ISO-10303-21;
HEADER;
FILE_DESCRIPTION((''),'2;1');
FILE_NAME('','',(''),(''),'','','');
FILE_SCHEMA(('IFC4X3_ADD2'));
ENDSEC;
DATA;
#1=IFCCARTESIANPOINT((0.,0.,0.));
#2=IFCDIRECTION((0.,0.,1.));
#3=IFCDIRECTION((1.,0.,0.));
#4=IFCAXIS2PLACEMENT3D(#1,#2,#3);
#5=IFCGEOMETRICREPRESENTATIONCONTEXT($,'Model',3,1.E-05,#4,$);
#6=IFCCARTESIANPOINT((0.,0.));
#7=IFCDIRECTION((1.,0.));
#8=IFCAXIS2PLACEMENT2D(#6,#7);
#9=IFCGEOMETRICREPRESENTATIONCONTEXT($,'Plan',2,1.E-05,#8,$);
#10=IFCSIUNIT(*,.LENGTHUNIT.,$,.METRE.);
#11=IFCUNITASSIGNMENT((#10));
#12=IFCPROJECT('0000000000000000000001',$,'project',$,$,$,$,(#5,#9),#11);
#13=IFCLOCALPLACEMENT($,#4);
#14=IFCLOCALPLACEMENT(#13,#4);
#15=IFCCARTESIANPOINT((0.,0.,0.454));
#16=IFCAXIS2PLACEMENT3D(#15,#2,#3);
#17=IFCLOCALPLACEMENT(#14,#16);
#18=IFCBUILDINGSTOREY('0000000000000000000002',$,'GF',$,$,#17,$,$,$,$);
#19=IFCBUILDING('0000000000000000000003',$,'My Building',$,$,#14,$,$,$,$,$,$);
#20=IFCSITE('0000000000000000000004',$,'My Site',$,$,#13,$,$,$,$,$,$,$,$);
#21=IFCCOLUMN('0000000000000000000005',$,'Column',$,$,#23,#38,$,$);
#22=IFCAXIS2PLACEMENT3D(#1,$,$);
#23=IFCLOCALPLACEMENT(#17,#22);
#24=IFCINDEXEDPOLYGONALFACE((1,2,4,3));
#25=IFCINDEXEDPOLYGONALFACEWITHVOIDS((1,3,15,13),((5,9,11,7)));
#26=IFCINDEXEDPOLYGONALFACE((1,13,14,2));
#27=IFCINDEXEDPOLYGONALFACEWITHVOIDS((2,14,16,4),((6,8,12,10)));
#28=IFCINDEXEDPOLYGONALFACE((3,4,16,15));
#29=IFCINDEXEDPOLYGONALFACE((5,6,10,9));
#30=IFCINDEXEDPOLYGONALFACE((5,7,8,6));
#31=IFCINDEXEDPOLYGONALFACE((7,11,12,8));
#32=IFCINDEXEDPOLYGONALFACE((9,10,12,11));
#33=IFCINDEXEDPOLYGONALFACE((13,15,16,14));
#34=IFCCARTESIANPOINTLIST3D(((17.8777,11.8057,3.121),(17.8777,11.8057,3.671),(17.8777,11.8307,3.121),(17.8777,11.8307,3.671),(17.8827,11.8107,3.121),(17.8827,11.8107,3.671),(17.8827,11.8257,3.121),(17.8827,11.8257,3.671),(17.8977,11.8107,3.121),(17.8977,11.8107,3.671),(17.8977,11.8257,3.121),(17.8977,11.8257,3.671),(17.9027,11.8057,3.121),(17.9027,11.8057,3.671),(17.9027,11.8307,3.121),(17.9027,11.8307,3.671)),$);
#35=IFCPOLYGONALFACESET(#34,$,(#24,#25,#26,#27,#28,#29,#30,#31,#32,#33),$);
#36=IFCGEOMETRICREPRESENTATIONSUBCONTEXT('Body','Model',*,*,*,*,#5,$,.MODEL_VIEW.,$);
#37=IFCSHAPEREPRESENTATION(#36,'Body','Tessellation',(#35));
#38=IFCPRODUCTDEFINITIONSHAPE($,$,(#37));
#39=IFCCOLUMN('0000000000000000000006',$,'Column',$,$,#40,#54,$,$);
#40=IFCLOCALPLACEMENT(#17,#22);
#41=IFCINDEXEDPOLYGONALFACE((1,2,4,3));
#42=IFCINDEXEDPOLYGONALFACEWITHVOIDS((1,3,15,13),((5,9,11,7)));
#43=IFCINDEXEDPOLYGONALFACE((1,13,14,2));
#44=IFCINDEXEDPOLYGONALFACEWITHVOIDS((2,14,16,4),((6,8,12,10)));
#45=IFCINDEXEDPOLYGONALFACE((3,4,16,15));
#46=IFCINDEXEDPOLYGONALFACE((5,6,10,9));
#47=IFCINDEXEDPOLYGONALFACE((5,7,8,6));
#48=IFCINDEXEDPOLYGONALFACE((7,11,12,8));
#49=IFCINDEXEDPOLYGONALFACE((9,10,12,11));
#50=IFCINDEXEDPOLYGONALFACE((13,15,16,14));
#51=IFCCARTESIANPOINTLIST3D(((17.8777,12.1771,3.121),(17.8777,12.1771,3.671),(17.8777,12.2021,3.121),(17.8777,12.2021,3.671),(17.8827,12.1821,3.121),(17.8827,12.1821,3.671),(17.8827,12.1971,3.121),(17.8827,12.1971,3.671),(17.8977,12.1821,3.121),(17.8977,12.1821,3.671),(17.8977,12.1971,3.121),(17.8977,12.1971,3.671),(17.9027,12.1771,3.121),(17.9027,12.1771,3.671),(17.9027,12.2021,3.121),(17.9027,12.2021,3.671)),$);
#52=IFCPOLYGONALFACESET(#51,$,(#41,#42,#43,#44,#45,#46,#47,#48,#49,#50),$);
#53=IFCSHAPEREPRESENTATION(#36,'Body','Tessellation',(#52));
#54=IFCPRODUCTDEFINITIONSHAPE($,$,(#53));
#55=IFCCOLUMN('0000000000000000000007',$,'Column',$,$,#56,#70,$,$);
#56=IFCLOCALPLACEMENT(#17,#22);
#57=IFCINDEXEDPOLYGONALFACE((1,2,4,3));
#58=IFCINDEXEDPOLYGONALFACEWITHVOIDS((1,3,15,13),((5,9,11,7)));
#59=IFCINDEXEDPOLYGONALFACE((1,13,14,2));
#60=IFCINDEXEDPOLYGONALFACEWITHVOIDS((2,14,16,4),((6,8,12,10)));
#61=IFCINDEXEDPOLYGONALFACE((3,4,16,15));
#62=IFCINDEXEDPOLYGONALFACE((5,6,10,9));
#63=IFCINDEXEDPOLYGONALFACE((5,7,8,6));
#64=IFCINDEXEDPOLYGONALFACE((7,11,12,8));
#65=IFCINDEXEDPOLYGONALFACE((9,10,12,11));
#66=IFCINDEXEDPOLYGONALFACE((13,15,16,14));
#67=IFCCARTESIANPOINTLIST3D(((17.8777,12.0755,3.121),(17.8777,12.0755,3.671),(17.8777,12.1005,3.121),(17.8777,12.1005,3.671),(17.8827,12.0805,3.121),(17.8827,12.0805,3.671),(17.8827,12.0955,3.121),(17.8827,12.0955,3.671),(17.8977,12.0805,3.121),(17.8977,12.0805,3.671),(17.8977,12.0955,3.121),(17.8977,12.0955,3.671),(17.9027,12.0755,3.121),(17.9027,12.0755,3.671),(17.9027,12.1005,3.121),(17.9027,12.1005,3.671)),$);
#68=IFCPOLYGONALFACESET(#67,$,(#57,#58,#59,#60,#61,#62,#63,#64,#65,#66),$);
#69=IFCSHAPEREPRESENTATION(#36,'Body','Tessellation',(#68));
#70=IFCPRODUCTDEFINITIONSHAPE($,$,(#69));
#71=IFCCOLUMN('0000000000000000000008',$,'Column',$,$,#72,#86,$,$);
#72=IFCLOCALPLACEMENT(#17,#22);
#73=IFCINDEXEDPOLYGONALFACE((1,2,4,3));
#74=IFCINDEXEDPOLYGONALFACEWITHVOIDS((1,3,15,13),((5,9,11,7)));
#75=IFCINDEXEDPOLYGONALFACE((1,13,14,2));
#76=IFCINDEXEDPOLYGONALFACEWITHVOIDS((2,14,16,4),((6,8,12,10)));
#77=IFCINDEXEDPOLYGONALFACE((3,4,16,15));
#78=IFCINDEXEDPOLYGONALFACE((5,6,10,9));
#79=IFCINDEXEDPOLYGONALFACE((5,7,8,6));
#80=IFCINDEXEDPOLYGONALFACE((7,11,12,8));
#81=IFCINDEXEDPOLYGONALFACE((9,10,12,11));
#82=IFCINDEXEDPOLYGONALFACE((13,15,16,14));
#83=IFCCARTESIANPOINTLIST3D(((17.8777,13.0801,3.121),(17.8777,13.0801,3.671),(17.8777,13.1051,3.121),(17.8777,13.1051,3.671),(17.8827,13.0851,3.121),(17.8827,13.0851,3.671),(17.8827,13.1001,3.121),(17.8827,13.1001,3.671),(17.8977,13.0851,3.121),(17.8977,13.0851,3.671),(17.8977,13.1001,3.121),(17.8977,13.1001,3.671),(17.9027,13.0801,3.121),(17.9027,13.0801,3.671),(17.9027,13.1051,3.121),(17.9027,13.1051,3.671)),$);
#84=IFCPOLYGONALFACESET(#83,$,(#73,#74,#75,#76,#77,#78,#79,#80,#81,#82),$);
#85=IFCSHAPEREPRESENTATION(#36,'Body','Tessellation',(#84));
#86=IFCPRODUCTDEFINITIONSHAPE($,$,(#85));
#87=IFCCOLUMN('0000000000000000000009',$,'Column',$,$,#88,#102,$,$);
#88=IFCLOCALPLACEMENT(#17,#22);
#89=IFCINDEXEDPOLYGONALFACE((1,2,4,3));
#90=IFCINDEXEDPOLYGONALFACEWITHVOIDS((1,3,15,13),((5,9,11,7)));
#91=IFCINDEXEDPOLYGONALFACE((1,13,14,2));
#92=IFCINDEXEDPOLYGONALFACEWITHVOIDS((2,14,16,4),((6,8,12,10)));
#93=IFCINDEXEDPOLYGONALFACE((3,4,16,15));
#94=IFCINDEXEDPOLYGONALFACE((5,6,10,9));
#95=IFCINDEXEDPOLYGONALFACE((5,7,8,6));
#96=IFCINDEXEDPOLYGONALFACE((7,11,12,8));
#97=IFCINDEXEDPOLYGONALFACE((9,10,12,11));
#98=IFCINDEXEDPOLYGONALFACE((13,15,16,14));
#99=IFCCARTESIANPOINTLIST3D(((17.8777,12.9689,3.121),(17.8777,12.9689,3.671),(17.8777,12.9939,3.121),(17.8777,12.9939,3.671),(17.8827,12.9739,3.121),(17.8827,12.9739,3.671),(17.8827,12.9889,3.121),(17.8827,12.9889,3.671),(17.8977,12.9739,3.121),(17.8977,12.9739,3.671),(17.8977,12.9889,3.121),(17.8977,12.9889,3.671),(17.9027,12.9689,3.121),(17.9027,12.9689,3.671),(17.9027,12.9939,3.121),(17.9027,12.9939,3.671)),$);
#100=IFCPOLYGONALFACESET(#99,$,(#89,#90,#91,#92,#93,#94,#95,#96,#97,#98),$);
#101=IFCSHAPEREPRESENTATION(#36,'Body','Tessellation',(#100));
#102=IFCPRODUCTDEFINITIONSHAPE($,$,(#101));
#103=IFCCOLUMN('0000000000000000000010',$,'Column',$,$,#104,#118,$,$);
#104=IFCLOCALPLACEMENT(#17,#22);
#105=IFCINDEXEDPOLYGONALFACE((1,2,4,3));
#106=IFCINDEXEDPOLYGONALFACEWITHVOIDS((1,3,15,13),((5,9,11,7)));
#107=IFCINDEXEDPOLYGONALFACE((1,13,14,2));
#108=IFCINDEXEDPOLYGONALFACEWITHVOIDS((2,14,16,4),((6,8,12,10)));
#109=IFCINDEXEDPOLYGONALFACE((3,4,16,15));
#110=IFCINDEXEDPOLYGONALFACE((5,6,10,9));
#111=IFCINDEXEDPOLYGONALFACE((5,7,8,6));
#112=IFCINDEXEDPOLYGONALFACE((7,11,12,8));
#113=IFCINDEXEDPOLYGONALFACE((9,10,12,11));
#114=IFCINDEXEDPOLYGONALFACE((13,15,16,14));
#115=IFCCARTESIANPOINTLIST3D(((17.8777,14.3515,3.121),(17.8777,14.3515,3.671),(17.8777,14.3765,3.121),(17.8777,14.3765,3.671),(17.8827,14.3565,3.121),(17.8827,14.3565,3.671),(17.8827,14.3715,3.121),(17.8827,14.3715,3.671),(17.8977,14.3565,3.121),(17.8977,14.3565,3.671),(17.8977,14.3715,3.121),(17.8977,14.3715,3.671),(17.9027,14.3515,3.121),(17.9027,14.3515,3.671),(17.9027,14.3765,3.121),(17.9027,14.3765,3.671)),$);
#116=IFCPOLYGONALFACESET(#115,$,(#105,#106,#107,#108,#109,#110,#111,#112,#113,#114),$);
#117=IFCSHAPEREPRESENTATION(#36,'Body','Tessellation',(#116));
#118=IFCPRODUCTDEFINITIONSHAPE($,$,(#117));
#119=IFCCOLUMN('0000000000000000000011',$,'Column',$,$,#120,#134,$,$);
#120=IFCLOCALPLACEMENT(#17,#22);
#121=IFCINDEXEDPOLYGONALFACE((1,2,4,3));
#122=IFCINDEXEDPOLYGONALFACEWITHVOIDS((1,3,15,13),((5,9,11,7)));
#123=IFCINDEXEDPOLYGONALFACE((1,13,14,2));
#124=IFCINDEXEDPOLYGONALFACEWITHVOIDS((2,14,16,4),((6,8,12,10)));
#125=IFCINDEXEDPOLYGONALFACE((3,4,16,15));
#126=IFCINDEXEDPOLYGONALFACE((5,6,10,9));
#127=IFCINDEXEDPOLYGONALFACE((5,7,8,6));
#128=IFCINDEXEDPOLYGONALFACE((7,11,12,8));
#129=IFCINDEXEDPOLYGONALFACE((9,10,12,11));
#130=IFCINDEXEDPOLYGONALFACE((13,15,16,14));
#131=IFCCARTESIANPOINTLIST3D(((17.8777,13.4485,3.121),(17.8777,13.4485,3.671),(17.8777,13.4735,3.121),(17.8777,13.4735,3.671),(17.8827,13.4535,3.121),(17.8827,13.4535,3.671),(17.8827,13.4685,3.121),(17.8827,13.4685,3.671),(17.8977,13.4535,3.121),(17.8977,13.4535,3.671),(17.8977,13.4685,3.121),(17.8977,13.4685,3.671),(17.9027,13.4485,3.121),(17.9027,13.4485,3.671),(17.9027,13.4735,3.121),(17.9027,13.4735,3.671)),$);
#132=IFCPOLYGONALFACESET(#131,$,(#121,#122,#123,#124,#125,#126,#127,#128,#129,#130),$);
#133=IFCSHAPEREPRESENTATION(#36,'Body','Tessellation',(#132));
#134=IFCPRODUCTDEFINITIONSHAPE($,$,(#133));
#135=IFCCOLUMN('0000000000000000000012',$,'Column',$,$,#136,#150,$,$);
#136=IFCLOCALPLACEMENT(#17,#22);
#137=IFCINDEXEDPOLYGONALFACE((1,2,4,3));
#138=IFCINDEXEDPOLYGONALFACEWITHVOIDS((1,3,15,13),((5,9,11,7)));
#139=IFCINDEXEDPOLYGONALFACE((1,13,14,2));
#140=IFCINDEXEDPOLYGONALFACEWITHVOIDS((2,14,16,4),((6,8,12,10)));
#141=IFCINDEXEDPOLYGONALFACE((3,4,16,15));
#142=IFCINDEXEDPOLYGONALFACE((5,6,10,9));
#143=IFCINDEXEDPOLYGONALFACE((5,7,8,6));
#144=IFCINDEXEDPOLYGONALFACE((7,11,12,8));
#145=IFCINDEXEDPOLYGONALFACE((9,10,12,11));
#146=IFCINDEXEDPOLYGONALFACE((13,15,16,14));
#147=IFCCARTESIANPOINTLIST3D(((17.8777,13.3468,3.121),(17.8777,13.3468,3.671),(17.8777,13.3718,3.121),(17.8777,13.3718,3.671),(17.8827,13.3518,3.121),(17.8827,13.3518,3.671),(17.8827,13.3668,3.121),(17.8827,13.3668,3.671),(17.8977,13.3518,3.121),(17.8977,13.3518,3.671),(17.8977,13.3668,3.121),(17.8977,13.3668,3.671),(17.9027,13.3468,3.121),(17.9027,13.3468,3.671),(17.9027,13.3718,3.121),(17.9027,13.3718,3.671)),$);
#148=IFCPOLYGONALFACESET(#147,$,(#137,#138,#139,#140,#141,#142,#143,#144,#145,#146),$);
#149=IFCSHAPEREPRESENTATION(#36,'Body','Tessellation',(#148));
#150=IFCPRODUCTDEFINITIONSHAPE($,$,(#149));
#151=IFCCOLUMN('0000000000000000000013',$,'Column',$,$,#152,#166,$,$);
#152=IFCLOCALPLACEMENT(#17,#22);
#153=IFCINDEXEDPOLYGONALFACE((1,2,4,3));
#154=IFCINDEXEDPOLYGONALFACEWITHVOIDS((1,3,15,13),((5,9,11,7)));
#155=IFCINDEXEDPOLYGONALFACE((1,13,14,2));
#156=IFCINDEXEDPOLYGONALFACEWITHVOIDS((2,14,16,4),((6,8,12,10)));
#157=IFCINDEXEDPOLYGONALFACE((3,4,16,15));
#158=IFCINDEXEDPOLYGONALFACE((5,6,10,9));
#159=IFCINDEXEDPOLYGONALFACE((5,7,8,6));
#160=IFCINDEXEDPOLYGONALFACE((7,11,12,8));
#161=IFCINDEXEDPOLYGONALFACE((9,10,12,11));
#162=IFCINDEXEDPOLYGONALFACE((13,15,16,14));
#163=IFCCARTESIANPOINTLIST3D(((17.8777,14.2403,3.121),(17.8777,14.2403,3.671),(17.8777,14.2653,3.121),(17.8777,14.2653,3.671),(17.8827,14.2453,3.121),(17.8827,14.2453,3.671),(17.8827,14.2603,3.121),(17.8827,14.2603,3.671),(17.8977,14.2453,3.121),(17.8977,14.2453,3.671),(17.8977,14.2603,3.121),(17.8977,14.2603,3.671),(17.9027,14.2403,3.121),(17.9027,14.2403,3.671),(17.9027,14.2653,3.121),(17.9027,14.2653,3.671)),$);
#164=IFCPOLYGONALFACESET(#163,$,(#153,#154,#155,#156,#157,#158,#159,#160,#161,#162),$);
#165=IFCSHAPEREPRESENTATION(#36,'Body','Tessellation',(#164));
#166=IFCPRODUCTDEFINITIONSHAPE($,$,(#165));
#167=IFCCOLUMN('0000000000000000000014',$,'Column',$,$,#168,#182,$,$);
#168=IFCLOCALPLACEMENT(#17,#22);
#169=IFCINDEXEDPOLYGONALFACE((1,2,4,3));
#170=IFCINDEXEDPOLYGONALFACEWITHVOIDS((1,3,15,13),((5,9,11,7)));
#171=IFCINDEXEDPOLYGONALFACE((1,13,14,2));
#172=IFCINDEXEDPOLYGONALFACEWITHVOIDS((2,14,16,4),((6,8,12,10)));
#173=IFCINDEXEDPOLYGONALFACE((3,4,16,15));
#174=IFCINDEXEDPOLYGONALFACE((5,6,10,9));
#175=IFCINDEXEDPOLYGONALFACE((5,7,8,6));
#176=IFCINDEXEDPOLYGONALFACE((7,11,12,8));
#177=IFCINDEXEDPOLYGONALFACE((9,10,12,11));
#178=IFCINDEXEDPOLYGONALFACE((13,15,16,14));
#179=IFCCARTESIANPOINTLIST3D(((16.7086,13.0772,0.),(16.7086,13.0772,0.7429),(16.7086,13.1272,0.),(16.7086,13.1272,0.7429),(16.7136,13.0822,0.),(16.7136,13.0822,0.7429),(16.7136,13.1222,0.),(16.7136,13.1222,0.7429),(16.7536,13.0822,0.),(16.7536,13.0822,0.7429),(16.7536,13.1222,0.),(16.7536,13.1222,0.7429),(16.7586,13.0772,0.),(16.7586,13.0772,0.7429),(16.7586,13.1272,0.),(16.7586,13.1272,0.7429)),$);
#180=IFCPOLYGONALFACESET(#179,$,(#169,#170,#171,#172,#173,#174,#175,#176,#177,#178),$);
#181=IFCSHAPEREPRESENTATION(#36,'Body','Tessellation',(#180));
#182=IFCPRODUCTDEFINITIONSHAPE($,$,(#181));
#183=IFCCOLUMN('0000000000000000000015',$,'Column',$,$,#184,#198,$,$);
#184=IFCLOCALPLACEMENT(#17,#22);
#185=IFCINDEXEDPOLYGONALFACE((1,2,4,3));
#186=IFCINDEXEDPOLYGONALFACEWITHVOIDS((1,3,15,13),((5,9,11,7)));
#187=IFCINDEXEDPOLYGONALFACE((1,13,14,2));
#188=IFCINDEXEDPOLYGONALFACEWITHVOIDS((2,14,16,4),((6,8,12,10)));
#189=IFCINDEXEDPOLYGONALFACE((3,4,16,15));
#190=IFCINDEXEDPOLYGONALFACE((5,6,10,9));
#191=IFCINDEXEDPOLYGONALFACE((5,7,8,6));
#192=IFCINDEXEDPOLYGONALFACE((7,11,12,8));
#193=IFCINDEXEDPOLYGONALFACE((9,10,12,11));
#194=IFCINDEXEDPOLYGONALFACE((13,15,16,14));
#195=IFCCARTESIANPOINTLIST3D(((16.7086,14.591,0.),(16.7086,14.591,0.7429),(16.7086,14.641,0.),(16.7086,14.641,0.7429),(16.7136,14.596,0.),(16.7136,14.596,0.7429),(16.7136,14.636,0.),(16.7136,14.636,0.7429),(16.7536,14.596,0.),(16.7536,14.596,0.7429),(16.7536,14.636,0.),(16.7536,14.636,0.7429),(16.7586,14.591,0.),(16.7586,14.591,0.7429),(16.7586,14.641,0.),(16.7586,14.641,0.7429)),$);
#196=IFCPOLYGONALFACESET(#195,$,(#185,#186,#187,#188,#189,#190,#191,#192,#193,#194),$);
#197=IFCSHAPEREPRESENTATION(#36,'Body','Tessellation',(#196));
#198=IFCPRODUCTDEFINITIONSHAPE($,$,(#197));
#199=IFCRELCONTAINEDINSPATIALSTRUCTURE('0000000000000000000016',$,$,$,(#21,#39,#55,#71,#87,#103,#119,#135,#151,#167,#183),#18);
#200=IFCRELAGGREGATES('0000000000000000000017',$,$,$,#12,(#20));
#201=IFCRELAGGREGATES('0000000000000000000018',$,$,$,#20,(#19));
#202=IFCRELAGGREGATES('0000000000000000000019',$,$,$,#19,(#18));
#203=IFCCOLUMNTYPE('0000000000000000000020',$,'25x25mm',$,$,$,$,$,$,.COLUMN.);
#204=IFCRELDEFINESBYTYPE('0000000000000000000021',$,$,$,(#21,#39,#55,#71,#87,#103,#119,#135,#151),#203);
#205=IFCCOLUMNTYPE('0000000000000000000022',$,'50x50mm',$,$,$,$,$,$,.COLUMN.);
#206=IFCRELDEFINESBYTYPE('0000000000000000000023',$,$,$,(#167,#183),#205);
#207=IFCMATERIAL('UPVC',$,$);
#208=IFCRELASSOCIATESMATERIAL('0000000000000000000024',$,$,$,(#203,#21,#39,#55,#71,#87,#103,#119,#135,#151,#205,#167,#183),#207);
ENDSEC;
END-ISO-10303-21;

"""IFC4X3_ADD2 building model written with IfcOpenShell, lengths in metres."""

from ifc_helpers import new_model, si_unit, frame, origin_with_axes, origin_2d_with_axis, place, context, subcontext, project, spatial, hollow_rectangle, extrude, material, material_profile, profile_set, profile_usage, type_object, element, save


model = new_model("IFC4X3_ADD2")

# Units and contexts
model_context = context("Model", 3, precision=1e-05, world=origin_with_axes())
plan_context = context("Plan", 2, precision=1e-05, world=origin_2d_with_axis())
body_context = subcontext(model_context, "Body", "Model", "MODEL_VIEW")
ifc_project = project(units=[si_unit("LENGTHUNIT", "METRE")], contexts=[model_context, plan_context])

# Site, building, storey
site_placement = place(None, origin_with_axes())
site = spatial("IfcSite", under=ifc_project, at=site_placement, Name="My Site")
building_placement = place(site_placement, origin_with_axes())
building = spatial("IfcBuilding", under=site, at=building_placement, Name="My Building")
storey_placement = place(building_placement, frame((0.0, 0.0, 0.454), z_axis=(0.0, 0.0, 1.0), x_axis=(1.0, 0.0, 0.0)))
storey = spatial("IfcBuildingStorey", under=building, at=storey_placement, Name="GF")

# Columns
ifc_material = material(Name="UPVC")
ifc_material_profile_1 = material_profile(ifc_material, hollow_rectangle(XDim=0.025, YDim=0.025, WallThickness=0.005))
ifc_profile_set_1 = profile_set([ifc_material_profile_1])
column_type_1 = type_object("IfcColumnType", Name="25x25mm", PredefinedType="COLUMN", material=ifc_profile_set_1)
ifc_profile_usage_1 = profile_usage(ifc_profile_set_1)
column_1_placement = place(storey_placement, frame((17.8902, 11.8182, 3.121), z_axis=(0.0, 0.0, 1.0), x_axis=(0.0, -1.0, 0.0)))
element("IfcColumn", 1, at=column_1_placement, inside=storey, type_object=column_type_1, material=ifc_profile_usage_1, Name="Column", context=body_context, shape_type="SweptSolid", body=[
    extrude(hollow_rectangle(XDim=0.025, YDim=0.025, WallThickness=0.005), origin_with_axes(), (0.0, 0.0, 1.0), 0.55),
])
ifc_profile_usage_2 = profile_usage(ifc_profile_set_1)
column_2_placement = place(storey_placement, frame((17.8902, 12.1896, 3.121), z_axis=(0.0, 0.0, 1.0), x_axis=(0.0, -1.0, 0.0)))
element("IfcColumn", 2, at=column_2_placement, inside=storey, type_object=column_type_1, material=ifc_profile_usage_2, Name="Column", context=body_context, shape_type="SweptSolid", body=[
    extrude(hollow_rectangle(XDim=0.025, YDim=0.025, WallThickness=0.005), origin_with_axes(), (0.0, 0.0, 1.0), 0.55),
])
ifc_profile_usage_3 = profile_usage(ifc_profile_set_1)
column_3_placement = place(storey_placement, frame((17.8902, 12.088, 3.121), z_axis=(0.0, 0.0, 1.0), x_axis=(0.0, -1.0, 0.0)))
element("IfcColumn", 3, at=column_3_placement, inside=storey, type_object=column_type_1, material=ifc_profile_usage_3, Name="Column", context=body_context, shape_type="SweptSolid", body=[
    extrude(hollow_rectangle(XDim=0.025, YDim=0.025, WallThickness=0.005), origin_with_axes(), (0.0, 0.0, 1.0), 0.55),
])
ifc_profile_usage_4 = profile_usage(ifc_profile_set_1)
column_4_placement = place(storey_placement, frame((17.8902, 13.0926, 3.121), z_axis=(0.0, 0.0, 1.0), x_axis=(0.0, -1.0, 0.0)))
element("IfcColumn", 4, at=column_4_placement, inside=storey, type_object=column_type_1, material=ifc_profile_usage_4, Name="Column", context=body_context, shape_type="SweptSolid", body=[
    extrude(hollow_rectangle(XDim=0.025, YDim=0.025, WallThickness=0.005), origin_with_axes(), (0.0, 0.0, 1.0), 0.55),
])
ifc_profile_usage_5 = profile_usage(ifc_profile_set_1)
column_5_placement = place(storey_placement, frame((17.8902, 12.9814, 3.121), z_axis=(0.0, 0.0, 1.0), x_axis=(0.0, -1.0, 0.0)))
element("IfcColumn", 5, at=column_5_placement, inside=storey, type_object=column_type_1, material=ifc_profile_usage_5, Name="Column", context=body_context, shape_type="SweptSolid", body=[
    extrude(hollow_rectangle(XDim=0.025, YDim=0.025, WallThickness=0.005), origin_with_axes(), (0.0, 0.0, 1.0), 0.55),
])
ifc_profile_usage_6 = profile_usage(ifc_profile_set_1)
column_6_placement = place(storey_placement, frame((17.8902, 14.364, 3.121), z_axis=(0.0, 0.0, 1.0), x_axis=(0.0, -1.0, 0.0)))
element("IfcColumn", 6, at=column_6_placement, inside=storey, type_object=column_type_1, material=ifc_profile_usage_6, Name="Column", context=body_context, shape_type="SweptSolid", body=[
    extrude(hollow_rectangle(XDim=0.025, YDim=0.025, WallThickness=0.005), origin_with_axes(), (0.0, 0.0, 1.0), 0.55),
])
ifc_profile_usage_7 = profile_usage(ifc_profile_set_1)
column_7_placement = place(storey_placement, frame((17.8902, 13.461, 3.121), z_axis=(0.0, 0.0, 1.0), x_axis=(0.0, -1.0, 0.0)))
element("IfcColumn", 7, at=column_7_placement, inside=storey, type_object=column_type_1, material=ifc_profile_usage_7, Name="Column", context=body_context, shape_type="SweptSolid", body=[
    extrude(hollow_rectangle(XDim=0.025, YDim=0.025, WallThickness=0.005), origin_with_axes(), (0.0, 0.0, 1.0), 0.55),
])
ifc_profile_usage_8 = profile_usage(ifc_profile_set_1)
column_8_placement = place(storey_placement, frame((17.8902, 13.3593, 3.121), z_axis=(0.0, 0.0, 1.0), x_axis=(0.0, -1.0, 0.0)))
element("IfcColumn", 8, at=column_8_placement, inside=storey, type_object=column_type_1, material=ifc_profile_usage_8, Name="Column", context=body_context, shape_type="SweptSolid", body=[
    extrude(hollow_rectangle(XDim=0.025, YDim=0.025, WallThickness=0.005), origin_with_axes(), (0.0, 0.0, 1.0), 0.55),
])
ifc_profile_usage_9 = profile_usage(ifc_profile_set_1)
column_9_placement = place(storey_placement, frame((17.8902, 14.2528, 3.121), z_axis=(0.0, 0.0, 1.0), x_axis=(0.0, -1.0, 0.0)))
element("IfcColumn", 9, at=column_9_placement, inside=storey, type_object=column_type_1, material=ifc_profile_usage_9, Name="Column", context=body_context, shape_type="SweptSolid", body=[
    extrude(hollow_rectangle(XDim=0.025, YDim=0.025, WallThickness=0.005), origin_with_axes(), (0.0, 0.0, 1.0), 0.55),
])
ifc_material_profile_2 = material_profile(ifc_material, hollow_rectangle(XDim=0.05, YDim=0.05, WallThickness=0.005))
ifc_profile_set_2 = profile_set([ifc_material_profile_2])
ifc_profile_usage_10 = profile_usage(ifc_profile_set_2)
column_type_2 = type_object("IfcColumnType", Name="50x50mm", PredefinedType="COLUMN", material=ifc_profile_set_2)
column_10_placement = place(storey_placement, frame((16.7336, 13.1022, 0.0), z_axis=(0.0, 0.0, 1.0), x_axis=(0.0, -1.0, 0.0)))
element("IfcColumn", 10, at=column_10_placement, inside=storey, type_object=column_type_2, material=ifc_profile_usage_10, Name="Column", context=body_context, shape_type="SweptSolid", body=[
    extrude(hollow_rectangle(XDim=0.05, YDim=0.05, WallThickness=0.005), origin_with_axes(), (0.0, 0.0, 1.0), 0.7429),
])
ifc_profile_usage_11 = profile_usage(ifc_profile_set_2)
column_11_placement = place(storey_placement, frame((16.7336, 14.616, 0.0), z_axis=(0.0, 0.0, 1.0), x_axis=(0.0, -1.0, 0.0)))
element("IfcColumn", 11, at=column_11_placement, inside=storey, type_object=column_type_2, material=ifc_profile_usage_11, Name="Column", context=body_context, shape_type="SweptSolid", body=[
    extrude(hollow_rectangle(XDim=0.05, YDim=0.05, WallThickness=0.005), origin_with_axes(), (0.0, 0.0, 1.0), 0.7429),
])

save(model, "model.ifc")
